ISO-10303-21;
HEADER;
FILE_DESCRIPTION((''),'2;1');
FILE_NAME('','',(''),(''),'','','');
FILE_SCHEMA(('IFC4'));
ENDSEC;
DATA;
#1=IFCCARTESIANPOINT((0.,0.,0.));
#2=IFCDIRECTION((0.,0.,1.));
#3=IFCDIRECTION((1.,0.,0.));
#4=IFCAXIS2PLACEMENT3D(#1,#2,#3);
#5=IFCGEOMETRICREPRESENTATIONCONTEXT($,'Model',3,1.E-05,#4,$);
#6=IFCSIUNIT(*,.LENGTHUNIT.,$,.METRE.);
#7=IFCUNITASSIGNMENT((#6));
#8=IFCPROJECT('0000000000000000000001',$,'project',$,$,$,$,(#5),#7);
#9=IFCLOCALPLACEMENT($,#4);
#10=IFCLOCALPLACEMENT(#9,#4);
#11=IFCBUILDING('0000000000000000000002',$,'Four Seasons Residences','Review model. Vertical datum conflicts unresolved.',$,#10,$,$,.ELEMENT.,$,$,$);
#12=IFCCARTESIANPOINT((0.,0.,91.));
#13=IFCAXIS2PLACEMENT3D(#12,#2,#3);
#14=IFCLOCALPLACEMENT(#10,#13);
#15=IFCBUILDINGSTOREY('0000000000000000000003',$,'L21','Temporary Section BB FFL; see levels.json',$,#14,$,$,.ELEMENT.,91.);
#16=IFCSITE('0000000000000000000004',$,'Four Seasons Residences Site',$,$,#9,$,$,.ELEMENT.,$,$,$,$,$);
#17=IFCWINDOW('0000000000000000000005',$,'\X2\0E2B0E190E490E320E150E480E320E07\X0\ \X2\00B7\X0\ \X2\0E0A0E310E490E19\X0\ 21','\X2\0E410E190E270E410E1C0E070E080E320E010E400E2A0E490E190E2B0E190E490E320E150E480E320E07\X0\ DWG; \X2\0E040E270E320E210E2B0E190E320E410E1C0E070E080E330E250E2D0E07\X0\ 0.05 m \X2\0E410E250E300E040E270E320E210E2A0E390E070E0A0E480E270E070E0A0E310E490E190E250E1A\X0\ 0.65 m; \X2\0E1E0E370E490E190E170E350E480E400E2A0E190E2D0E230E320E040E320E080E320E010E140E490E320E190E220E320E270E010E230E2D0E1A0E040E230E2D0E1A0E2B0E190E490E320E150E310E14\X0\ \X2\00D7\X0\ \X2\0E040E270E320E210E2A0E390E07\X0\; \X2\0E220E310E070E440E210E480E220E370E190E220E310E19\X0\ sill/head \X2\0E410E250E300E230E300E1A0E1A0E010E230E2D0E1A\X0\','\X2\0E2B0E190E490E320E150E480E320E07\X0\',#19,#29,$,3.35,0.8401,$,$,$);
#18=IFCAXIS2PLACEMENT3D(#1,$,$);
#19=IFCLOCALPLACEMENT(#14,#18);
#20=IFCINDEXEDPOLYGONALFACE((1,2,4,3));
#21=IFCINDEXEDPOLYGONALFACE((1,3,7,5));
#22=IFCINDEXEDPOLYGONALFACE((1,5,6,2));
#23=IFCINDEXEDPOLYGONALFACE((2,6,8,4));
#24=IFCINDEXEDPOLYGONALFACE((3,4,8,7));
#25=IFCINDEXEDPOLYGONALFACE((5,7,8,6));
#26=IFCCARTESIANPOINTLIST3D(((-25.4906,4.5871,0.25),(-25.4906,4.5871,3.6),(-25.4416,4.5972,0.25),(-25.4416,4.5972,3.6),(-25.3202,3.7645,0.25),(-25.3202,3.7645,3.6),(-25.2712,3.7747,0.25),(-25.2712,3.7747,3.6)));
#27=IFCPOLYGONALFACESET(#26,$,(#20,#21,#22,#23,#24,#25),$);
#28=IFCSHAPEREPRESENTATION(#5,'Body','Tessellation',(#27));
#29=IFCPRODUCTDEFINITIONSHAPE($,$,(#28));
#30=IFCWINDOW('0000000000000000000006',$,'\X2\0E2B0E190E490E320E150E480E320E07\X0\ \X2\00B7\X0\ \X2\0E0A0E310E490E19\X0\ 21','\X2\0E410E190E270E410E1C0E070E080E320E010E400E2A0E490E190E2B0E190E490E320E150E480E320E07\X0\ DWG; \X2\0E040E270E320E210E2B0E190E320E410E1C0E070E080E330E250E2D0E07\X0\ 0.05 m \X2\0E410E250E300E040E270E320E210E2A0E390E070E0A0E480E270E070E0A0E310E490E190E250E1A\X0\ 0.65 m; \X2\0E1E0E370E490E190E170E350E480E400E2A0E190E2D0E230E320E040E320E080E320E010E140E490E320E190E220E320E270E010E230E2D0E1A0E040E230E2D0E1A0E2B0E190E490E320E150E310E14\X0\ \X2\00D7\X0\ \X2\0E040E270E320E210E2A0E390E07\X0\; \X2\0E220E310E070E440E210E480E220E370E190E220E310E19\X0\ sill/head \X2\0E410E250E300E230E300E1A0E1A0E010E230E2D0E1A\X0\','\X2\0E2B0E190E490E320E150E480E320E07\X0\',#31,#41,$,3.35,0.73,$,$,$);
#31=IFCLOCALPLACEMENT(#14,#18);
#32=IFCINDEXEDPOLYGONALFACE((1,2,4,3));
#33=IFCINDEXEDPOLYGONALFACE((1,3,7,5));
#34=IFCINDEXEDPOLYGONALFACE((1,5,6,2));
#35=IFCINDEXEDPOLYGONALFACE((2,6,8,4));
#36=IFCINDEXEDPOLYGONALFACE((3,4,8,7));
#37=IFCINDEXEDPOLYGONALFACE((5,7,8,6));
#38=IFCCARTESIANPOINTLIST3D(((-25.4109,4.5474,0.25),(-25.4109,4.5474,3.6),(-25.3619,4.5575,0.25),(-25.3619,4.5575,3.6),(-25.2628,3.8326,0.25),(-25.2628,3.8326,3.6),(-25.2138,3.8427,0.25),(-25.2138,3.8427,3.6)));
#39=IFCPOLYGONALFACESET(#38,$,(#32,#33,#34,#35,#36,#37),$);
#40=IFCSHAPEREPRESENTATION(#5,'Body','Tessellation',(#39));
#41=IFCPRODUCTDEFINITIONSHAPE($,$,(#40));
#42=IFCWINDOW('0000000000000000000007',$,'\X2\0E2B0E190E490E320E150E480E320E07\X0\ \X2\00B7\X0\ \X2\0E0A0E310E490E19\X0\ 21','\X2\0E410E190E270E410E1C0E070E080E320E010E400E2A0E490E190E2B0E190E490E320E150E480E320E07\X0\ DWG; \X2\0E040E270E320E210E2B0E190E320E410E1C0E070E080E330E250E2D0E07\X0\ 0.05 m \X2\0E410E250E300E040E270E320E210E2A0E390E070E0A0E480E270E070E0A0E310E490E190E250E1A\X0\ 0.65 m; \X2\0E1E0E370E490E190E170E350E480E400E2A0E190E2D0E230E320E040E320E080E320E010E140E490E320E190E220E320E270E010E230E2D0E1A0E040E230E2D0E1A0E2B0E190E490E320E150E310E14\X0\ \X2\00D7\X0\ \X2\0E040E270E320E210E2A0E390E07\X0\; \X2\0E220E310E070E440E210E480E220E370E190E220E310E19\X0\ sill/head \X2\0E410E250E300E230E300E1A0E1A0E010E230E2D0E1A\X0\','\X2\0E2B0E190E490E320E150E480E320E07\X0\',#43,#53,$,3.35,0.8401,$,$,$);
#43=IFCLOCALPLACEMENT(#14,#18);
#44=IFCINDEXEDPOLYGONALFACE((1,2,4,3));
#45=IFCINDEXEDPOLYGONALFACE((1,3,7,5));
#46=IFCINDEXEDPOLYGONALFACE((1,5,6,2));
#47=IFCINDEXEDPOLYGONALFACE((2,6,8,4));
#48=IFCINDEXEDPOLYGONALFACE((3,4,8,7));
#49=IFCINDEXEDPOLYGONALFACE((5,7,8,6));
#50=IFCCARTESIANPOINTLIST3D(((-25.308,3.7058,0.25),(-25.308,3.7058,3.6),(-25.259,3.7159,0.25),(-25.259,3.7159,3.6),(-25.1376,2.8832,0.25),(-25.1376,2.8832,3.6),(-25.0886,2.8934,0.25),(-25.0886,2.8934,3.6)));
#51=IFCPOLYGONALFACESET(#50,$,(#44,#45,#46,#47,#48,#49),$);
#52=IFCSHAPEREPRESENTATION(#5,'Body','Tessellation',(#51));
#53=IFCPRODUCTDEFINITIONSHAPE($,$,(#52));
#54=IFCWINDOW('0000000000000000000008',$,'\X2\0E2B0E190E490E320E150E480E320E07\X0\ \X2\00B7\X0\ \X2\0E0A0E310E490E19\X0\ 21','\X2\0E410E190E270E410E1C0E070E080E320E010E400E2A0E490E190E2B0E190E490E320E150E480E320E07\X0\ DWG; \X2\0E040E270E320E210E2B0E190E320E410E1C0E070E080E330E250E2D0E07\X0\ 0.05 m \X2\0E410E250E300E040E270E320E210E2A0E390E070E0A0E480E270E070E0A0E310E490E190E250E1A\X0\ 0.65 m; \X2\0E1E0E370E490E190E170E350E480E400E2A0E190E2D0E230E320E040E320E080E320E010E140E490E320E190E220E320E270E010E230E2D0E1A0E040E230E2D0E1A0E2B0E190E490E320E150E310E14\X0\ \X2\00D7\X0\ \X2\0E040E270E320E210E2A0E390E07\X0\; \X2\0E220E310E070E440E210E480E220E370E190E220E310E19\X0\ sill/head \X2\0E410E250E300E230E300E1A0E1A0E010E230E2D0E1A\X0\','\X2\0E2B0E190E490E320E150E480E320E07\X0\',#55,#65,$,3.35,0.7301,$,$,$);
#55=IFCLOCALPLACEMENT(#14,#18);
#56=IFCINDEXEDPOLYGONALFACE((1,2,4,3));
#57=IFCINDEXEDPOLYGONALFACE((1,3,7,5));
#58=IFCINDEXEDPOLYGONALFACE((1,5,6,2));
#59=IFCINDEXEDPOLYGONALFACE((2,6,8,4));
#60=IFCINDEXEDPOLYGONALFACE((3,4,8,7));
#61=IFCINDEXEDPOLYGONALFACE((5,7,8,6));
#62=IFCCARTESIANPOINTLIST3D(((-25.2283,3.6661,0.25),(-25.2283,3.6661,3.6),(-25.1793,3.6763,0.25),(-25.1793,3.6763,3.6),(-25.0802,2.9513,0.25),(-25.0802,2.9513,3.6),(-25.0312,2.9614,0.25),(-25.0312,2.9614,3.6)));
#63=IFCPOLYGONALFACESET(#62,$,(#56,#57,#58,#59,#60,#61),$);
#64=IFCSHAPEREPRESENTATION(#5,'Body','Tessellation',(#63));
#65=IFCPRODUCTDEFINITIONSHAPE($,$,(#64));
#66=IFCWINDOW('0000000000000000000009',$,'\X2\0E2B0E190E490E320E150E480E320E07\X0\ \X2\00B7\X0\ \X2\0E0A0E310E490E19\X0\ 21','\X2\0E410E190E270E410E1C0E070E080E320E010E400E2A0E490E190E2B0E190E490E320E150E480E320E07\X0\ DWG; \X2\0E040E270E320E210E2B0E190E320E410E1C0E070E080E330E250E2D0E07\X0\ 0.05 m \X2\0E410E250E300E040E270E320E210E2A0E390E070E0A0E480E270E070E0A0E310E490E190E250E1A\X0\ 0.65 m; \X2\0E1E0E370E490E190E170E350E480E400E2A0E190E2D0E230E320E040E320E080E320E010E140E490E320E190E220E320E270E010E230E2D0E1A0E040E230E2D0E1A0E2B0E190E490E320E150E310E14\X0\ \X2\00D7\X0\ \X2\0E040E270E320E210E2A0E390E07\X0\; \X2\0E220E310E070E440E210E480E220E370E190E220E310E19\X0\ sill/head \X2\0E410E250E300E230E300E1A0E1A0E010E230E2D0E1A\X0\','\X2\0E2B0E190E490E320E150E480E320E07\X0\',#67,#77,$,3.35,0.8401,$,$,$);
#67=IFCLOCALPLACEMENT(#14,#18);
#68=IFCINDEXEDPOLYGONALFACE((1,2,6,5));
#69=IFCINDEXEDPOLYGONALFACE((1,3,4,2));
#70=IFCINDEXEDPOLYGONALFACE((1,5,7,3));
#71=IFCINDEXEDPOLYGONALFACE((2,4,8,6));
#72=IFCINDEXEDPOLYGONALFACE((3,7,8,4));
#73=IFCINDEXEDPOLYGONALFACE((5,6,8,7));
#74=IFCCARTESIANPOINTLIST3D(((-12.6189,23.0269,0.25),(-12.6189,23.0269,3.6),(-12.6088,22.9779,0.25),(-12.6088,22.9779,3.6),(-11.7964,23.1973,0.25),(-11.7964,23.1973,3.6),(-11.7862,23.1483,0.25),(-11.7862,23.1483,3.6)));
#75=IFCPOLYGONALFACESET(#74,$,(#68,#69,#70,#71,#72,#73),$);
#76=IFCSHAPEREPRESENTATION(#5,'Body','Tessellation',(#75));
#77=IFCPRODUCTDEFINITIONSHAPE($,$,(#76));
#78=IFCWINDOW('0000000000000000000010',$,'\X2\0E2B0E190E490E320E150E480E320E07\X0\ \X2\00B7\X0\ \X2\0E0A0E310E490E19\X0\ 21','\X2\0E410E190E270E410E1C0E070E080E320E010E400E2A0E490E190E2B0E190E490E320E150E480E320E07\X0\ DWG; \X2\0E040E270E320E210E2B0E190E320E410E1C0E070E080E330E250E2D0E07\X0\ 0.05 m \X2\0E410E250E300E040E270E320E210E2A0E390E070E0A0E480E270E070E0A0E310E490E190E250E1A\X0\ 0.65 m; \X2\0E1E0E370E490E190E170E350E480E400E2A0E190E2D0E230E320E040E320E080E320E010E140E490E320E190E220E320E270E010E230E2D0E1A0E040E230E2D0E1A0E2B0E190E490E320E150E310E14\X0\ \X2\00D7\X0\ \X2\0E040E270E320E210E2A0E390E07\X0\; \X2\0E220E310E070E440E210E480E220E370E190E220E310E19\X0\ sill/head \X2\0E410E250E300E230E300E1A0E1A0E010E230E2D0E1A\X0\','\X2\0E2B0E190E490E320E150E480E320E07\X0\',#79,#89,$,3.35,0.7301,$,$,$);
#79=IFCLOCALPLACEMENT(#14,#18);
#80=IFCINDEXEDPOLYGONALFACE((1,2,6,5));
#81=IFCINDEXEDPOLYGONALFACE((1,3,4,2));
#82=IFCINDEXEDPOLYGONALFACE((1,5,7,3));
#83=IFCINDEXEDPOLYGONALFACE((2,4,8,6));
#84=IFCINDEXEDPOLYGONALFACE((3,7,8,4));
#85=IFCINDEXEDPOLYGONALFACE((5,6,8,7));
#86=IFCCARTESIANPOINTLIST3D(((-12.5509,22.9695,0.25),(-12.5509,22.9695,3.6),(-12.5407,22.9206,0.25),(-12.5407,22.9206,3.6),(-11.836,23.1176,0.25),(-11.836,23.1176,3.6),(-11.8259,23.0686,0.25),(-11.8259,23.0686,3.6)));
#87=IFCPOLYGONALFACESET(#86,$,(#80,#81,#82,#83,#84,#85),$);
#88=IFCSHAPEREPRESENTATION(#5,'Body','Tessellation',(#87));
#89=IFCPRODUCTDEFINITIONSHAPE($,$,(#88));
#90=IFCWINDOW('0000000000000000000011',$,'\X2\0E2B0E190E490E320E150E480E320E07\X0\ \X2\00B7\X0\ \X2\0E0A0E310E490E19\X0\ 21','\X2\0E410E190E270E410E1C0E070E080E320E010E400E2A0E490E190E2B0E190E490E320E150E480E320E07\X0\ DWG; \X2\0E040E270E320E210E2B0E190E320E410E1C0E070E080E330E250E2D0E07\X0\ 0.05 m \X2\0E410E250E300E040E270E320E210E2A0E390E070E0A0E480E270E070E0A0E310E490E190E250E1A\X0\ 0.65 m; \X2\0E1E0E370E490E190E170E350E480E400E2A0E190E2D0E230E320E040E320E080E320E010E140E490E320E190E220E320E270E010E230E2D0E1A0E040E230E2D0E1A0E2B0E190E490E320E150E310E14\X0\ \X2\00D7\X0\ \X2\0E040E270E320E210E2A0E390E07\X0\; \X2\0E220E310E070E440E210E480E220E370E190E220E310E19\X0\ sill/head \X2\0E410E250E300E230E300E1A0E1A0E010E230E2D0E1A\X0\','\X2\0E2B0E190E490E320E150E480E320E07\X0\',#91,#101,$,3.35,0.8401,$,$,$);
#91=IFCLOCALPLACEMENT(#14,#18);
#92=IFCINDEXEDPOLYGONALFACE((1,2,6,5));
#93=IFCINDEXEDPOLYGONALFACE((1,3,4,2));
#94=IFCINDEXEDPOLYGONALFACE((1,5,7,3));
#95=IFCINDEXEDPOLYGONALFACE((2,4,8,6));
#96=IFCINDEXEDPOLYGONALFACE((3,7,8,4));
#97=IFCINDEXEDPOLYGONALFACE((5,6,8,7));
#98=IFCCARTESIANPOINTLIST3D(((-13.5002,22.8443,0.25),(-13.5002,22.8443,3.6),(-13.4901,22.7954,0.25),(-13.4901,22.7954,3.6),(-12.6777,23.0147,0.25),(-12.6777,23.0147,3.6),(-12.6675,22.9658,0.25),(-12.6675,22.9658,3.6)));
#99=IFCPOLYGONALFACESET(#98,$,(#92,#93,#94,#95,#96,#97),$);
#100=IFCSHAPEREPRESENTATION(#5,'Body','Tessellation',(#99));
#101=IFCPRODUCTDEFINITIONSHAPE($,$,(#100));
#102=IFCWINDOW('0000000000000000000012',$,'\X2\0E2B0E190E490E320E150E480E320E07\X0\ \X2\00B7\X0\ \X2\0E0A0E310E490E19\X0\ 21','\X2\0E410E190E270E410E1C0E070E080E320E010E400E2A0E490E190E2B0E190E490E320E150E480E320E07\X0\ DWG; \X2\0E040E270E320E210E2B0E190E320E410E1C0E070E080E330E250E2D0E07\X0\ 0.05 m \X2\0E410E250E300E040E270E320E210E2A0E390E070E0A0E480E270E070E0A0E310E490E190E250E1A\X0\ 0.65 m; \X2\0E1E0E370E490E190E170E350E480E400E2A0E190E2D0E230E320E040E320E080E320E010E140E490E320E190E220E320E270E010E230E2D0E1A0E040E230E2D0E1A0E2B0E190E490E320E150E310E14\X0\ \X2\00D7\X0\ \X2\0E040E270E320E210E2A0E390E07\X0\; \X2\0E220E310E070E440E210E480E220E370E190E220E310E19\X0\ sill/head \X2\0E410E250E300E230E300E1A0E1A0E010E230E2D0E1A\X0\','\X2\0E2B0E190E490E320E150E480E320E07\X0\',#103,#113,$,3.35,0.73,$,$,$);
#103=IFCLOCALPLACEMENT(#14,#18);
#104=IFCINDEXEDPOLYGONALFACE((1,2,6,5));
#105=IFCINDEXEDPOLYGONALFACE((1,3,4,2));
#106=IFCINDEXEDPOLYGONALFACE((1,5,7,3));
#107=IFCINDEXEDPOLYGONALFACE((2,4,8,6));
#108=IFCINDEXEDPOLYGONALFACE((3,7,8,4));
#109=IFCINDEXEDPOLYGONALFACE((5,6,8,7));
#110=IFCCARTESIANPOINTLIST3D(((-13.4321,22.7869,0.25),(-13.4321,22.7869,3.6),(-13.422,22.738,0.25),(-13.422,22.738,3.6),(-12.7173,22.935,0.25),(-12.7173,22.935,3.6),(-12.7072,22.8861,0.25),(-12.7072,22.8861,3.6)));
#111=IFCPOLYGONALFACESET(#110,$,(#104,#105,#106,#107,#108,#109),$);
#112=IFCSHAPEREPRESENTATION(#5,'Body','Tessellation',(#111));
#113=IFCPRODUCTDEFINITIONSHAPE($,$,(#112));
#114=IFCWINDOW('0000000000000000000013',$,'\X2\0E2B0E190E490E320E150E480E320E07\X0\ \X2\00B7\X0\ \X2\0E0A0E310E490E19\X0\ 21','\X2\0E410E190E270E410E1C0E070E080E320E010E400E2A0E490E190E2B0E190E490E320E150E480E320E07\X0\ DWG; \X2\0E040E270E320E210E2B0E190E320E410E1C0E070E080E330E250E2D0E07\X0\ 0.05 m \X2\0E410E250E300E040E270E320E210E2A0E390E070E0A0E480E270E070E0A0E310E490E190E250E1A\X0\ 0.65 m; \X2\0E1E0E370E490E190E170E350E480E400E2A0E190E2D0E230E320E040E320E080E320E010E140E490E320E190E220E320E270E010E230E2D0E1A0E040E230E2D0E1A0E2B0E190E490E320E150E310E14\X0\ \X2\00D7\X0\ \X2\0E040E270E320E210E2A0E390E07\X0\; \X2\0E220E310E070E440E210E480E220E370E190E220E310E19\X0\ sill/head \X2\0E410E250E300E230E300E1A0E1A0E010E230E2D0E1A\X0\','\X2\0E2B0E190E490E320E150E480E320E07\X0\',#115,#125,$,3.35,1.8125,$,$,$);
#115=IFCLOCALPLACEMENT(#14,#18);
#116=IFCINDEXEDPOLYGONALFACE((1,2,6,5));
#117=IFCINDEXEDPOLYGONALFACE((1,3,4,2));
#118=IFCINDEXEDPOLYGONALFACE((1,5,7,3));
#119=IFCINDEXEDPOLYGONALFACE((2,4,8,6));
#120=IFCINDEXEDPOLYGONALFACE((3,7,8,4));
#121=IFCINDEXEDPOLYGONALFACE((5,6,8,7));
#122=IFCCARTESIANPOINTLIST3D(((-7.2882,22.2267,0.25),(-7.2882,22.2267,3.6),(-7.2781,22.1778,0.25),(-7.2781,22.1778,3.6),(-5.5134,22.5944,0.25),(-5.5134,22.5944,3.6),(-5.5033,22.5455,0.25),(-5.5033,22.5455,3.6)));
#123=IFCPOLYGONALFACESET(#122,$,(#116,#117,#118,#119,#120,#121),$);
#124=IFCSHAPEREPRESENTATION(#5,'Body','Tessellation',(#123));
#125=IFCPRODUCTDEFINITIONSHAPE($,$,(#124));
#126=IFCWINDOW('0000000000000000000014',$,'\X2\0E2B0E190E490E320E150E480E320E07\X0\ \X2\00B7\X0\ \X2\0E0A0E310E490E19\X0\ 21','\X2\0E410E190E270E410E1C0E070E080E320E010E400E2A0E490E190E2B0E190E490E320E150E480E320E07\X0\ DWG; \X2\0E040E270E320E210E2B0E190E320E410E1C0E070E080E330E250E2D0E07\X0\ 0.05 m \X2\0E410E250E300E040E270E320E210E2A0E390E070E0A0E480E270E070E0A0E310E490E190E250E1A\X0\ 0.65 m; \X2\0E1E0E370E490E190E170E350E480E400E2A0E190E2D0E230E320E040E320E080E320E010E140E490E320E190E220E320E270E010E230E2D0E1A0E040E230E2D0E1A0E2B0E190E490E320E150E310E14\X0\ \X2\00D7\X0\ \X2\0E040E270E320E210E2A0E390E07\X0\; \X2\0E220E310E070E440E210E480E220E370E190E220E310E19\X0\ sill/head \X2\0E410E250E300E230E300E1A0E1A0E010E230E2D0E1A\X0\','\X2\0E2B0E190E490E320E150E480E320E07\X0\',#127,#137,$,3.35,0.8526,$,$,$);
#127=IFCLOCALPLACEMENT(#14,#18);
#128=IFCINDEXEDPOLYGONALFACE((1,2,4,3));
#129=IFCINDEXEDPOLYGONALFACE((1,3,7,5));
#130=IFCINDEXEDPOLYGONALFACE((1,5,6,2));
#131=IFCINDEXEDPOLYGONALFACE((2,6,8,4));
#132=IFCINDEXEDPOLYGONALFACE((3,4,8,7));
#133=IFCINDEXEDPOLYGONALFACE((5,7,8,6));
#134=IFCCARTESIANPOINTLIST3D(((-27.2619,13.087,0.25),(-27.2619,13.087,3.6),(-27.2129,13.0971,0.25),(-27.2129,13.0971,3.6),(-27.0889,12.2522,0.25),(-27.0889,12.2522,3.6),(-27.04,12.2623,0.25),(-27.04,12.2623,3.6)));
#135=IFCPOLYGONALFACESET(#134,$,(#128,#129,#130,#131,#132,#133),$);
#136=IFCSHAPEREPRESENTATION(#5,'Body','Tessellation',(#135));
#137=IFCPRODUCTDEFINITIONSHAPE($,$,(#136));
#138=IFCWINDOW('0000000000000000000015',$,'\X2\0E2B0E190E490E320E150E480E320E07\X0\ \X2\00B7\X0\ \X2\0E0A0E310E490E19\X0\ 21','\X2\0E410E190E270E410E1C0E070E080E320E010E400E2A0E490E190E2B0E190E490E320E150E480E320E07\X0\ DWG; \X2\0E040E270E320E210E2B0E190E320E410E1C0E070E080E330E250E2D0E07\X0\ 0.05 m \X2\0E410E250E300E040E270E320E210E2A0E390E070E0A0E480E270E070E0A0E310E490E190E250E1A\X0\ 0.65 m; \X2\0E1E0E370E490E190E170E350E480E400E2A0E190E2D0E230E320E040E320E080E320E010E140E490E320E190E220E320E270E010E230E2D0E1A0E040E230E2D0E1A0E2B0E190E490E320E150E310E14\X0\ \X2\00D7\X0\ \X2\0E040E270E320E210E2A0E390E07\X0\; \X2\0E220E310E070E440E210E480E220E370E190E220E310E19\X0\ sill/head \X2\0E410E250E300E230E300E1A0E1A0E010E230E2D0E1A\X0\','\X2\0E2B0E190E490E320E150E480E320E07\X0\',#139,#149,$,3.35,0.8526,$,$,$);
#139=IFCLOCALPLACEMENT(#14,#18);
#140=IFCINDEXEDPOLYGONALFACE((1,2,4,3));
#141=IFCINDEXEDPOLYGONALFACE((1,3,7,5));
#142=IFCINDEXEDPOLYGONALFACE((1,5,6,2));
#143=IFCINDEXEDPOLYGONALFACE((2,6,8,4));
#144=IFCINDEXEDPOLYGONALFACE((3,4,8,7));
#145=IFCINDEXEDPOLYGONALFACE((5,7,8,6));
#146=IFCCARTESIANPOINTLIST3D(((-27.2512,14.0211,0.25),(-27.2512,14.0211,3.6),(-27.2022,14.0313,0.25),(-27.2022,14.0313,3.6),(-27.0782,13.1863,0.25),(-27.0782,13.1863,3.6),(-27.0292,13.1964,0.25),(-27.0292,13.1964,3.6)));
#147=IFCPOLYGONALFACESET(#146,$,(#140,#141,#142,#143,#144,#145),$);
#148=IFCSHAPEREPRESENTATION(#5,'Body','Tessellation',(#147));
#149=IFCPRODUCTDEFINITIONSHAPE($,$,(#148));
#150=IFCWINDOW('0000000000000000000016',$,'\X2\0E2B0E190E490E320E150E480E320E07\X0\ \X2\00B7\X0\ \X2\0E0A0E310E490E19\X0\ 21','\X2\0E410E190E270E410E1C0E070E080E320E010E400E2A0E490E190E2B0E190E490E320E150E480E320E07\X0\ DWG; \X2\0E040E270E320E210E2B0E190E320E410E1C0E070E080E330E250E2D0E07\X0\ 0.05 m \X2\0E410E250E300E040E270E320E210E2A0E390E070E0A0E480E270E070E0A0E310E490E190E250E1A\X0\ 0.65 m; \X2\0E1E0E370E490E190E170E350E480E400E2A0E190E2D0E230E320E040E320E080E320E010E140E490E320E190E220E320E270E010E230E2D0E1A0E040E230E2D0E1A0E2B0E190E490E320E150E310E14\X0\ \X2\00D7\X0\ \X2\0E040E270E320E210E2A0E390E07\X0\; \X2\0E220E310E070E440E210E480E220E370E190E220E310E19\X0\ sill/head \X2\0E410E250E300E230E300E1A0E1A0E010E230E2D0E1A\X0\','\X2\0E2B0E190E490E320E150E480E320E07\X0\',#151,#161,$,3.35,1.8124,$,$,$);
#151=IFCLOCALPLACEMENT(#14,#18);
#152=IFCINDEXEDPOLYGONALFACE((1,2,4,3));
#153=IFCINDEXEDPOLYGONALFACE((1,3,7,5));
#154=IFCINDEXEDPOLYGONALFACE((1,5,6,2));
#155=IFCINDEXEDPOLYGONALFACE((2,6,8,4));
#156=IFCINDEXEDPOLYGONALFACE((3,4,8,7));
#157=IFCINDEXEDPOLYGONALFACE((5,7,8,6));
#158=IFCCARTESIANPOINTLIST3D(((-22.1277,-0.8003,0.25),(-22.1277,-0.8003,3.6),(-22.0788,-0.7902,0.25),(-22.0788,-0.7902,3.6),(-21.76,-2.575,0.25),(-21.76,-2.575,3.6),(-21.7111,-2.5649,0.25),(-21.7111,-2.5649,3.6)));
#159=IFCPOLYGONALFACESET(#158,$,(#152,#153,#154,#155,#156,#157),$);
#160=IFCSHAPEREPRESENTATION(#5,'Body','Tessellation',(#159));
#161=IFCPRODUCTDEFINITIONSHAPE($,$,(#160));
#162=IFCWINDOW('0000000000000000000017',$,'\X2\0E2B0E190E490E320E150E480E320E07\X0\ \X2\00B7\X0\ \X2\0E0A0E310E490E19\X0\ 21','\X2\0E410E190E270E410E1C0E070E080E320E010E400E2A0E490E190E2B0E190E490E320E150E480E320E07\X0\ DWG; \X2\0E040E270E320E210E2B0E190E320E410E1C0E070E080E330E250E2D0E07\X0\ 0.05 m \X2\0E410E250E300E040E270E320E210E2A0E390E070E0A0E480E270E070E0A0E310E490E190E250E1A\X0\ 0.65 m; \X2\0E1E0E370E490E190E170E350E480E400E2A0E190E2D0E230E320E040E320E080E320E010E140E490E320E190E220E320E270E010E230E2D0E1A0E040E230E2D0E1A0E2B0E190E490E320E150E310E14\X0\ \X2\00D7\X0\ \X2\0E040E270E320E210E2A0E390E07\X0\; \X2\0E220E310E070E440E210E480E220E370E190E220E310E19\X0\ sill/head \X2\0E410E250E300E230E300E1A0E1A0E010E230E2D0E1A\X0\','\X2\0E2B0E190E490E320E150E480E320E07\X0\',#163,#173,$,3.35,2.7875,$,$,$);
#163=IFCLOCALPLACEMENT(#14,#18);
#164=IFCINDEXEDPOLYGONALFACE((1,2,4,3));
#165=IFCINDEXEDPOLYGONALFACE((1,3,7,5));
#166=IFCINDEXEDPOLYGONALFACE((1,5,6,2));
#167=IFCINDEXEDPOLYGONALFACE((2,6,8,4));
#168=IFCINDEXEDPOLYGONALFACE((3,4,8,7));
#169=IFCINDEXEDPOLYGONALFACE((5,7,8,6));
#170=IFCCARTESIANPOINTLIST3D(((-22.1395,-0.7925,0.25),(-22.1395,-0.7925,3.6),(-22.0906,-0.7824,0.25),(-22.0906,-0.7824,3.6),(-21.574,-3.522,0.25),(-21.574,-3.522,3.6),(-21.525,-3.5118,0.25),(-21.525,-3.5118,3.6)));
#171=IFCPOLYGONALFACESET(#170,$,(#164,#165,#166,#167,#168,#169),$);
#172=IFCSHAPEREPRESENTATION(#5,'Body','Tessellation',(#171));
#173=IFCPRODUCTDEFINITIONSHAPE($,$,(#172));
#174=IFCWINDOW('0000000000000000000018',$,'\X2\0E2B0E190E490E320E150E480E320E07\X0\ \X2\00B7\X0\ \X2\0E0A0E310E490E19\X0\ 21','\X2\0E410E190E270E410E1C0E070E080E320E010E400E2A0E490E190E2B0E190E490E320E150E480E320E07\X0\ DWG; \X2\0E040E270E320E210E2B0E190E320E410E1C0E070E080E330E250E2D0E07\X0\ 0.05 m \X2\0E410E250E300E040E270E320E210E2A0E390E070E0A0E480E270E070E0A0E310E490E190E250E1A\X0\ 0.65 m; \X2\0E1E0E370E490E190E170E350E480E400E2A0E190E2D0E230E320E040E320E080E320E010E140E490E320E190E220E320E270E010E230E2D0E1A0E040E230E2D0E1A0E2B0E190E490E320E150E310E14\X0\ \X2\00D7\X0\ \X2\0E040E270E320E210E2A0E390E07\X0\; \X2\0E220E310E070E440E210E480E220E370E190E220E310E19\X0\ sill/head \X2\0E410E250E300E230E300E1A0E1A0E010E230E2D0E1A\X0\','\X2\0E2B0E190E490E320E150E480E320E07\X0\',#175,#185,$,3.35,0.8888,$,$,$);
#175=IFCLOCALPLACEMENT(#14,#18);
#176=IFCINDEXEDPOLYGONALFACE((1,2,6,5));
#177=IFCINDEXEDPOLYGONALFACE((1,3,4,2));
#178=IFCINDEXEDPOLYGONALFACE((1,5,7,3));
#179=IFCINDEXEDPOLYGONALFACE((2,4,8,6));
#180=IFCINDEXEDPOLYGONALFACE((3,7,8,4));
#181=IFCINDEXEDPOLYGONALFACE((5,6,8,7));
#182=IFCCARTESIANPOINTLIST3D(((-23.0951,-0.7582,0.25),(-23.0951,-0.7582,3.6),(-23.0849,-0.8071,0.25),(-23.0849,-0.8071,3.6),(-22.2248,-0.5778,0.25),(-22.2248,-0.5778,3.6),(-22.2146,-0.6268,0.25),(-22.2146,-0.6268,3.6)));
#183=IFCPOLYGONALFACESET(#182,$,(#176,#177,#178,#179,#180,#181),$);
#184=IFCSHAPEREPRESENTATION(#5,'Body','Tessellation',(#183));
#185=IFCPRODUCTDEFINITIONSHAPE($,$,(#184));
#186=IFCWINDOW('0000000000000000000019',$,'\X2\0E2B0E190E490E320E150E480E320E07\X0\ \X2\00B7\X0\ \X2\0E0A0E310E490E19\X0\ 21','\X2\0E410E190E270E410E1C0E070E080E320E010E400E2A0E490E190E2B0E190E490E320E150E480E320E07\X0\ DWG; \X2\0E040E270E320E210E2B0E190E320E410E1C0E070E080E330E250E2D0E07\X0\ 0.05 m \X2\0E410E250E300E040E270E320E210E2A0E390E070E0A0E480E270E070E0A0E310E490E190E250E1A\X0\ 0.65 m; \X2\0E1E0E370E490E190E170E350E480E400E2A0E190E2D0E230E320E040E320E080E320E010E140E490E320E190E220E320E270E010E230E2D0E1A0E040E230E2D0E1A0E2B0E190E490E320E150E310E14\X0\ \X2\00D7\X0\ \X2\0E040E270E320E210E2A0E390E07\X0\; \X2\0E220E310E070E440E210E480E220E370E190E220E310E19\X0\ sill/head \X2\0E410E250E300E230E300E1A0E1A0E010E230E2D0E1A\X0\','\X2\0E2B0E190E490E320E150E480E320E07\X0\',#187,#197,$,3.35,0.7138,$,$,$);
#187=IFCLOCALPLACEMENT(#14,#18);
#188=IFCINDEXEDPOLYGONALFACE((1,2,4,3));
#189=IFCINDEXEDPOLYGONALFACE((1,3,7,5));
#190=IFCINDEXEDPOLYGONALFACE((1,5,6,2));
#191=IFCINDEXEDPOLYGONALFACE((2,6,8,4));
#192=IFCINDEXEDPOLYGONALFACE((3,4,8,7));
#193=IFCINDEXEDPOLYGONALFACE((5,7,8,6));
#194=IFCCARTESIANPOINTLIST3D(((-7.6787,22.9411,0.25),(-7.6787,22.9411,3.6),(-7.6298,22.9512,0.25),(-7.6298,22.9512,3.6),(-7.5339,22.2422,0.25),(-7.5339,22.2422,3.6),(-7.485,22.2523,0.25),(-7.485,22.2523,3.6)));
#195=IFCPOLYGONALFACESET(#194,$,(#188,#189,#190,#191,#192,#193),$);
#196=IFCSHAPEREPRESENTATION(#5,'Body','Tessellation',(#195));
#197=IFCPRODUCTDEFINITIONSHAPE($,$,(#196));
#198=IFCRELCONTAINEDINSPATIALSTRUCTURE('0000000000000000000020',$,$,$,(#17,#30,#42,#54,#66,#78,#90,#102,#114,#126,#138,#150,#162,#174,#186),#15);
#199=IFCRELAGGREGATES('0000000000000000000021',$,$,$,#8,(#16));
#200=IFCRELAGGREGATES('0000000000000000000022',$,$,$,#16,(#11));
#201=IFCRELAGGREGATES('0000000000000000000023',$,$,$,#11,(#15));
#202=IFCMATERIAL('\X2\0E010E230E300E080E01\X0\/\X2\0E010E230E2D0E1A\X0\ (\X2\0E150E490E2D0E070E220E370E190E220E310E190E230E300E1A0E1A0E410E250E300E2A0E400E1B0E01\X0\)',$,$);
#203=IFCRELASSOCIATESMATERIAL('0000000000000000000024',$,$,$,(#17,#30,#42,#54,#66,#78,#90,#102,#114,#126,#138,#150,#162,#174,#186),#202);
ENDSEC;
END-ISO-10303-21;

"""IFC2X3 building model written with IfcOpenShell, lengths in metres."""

from ifc_helpers import new_model, si_unit, frame, origin_with_axes, place, context, project, spatial, polyline, outline, extrude, material, element, save


model = new_model("IFC2X3")

# Units and contexts
model_context = context("Model", 3, precision=1e-05, world=origin_with_axes())
ifc_project = project(units=[si_unit("LENGTHUNIT", "METRE")], contexts=[model_context])

# Site, building, storey
site_placement = place(None, origin_with_axes())
site = spatial("IfcSite", under=ifc_project, at=site_placement, Name="Four Seasons Residences Site", CompositionType="ELEMENT")
building_placement = place(site_placement, origin_with_axes())
building = spatial("IfcBuilding", under=site, at=building_placement, Name="Four Seasons Residences", Description="Review model. Vertical datum conflicts unresolved.", CompositionType="ELEMENT")
storey_placement = place(building_placement, frame((0.0, 0.0, 91.0), z_axis=(0.0, 0.0, 1.0), x_axis=(1.0, 0.0, 0.0)))
storey = spatial("IfcBuildingStorey", under=building, at=storey_placement, Name="L21", Description="Temporary Section BB FFL; see levels.json", CompositionType="ELEMENT", Elevation=91.0)

# Windows
ifc_material = material(Name="กระจก/กรอบ (ต้องยืนยันระบบและสเปก)")
window_1_placement = place(storey_placement, origin_with_axes())
element("IfcWindow", 1, at=window_1_placement, inside=storey, material=ifc_material, Name="หน้าต่าง · ชั้น 21", Description="แนวแผงจากเส้นหน้าต่าง DWG; ความหนาแผงจำลอง 0.05 m และความสูงช่วงชั้นลบ 0.65 m; พื้นที่เสนอราคาจากด้านยาวกรอบครอบหน้าตัด × ความสูง; ยังไม่ยืนยัน sill/head และระบบกรอบ", ObjectType="หน้าต่าง", OverallHeight=3.35, OverallWidth=0.8401, context=model_context, shape_type="SweptSolid", body=[
    extrude(outline(polyline([(-25.2712, 3.7747), (-25.3202, 3.7645), (-25.4906, 4.5871), (-25.4416, 4.5972), (-25.2712, 3.7747)])), frame((0.0, 0.0, 0.25), z_axis=(0.0, 0.0, 1.0), x_axis=(1.0, 0.0, 0.0)), (0.0, 0.0, 1.0), 3.35),
])
window_2_placement = place(storey_placement, origin_with_axes())
element("IfcWindow", 2, at=window_2_placement, inside=storey, material=ifc_material, Name="หน้าต่าง · ชั้น 21", Description="แนวแผงจากเส้นหน้าต่าง DWG; ความหนาแผงจำลอง 0.05 m และความสูงช่วงชั้นลบ 0.65 m; พื้นที่เสนอราคาจากด้านยาวกรอบครอบหน้าตัด × ความสูง; ยังไม่ยืนยัน sill/head และระบบกรอบ", ObjectType="หน้าต่าง", OverallHeight=3.35, OverallWidth=0.73, context=model_context, shape_type="SweptSolid", body=[
    extrude(outline(polyline([(-25.2138, 3.8427), (-25.2628, 3.8326), (-25.4109, 4.5474), (-25.3619, 4.5575), (-25.2138, 3.8427)])), frame((0.0, 0.0, 0.25), z_axis=(0.0, 0.0, 1.0), x_axis=(1.0, 0.0, 0.0)), (0.0, 0.0, 1.0), 3.35),
])
window_3_placement = place(storey_placement, origin_with_axes())
element("IfcWindow", 3, at=window_3_placement, inside=storey, material=ifc_material, Name="หน้าต่าง · ชั้น 21", Description="แนวแผงจากเส้นหน้าต่าง DWG; ความหนาแผงจำลอง 0.05 m และความสูงช่วงชั้นลบ 0.65 m; พื้นที่เสนอราคาจากด้านยาวกรอบครอบหน้าตัด × ความสูง; ยังไม่ยืนยัน sill/head และระบบกรอบ", ObjectType="หน้าต่าง", OverallHeight=3.35, OverallWidth=0.8401, context=model_context, shape_type="SweptSolid", body=[
    extrude(outline(polyline([(-25.0886, 2.8934), (-25.1376, 2.8832), (-25.308, 3.7058), (-25.259, 3.7159), (-25.0886, 2.8934)])), frame((0.0, 0.0, 0.25), z_axis=(0.0, 0.0, 1.0), x_axis=(1.0, 0.0, 0.0)), (0.0, 0.0, 1.0), 3.35),
])
window_4_placement = place(storey_placement, origin_with_axes())
element("IfcWindow", 4, at=window_4_placement, inside=storey, material=ifc_material, Name="หน้าต่าง · ชั้น 21", Description="แนวแผงจากเส้นหน้าต่าง DWG; ความหนาแผงจำลอง 0.05 m และความสูงช่วงชั้นลบ 0.65 m; พื้นที่เสนอราคาจากด้านยาวกรอบครอบหน้าตัด × ความสูง; ยังไม่ยืนยัน sill/head และระบบกรอบ", ObjectType="หน้าต่าง", OverallHeight=3.35, OverallWidth=0.7301, context=model_context, shape_type="SweptSolid", body=[
    extrude(outline(polyline([(-25.0312, 2.9614), (-25.0802, 2.9513), (-25.2283, 3.6661), (-25.1793, 3.6763), (-25.0312, 2.9614)])), frame((0.0, 0.0, 0.25), z_axis=(0.0, 0.0, 1.0), x_axis=(1.0, 0.0, 0.0)), (0.0, 0.0, 1.0), 3.35),
])
window_5_placement = place(storey_placement, origin_with_axes())
element("IfcWindow", 5, at=window_5_placement, inside=storey, material=ifc_material, Name="หน้าต่าง · ชั้น 21", Description="แนวแผงจากเส้นหน้าต่าง DWG; ความหนาแผงจำลอง 0.05 m และความสูงช่วงชั้นลบ 0.65 m; พื้นที่เสนอราคาจากด้านยาวกรอบครอบหน้าตัด × ความสูง; ยังไม่ยืนยัน sill/head และระบบกรอบ", ObjectType="หน้าต่าง", OverallHeight=3.35, OverallWidth=0.8401, context=model_context, shape_type="SweptSolid", body=[
    extrude(outline(polyline([(-12.6088, 22.9779), (-12.6189, 23.0269), (-11.7964, 23.1973), (-11.7862, 23.1483), (-12.6088, 22.9779)])), frame((0.0, 0.0, 0.25), z_axis=(0.0, 0.0, 1.0), x_axis=(1.0, 0.0, 0.0)), (0.0, 0.0, 1.0), 3.35),
])
window_6_placement = place(storey_placement, origin_with_axes())
element("IfcWindow", 6, at=window_6_placement, inside=storey, material=ifc_material, Name="หน้าต่าง · ชั้น 21", Description="แนวแผงจากเส้นหน้าต่าง DWG; ความหนาแผงจำลอง 0.05 m และความสูงช่วงชั้นลบ 0.65 m; พื้นที่เสนอราคาจากด้านยาวกรอบครอบหน้าตัด × ความสูง; ยังไม่ยืนยัน sill/head และระบบกรอบ", ObjectType="หน้าต่าง", OverallHeight=3.35, OverallWidth=0.7301, context=model_context, shape_type="SweptSolid", body=[
    extrude(outline(polyline([(-12.5407, 22.9206), (-12.5509, 22.9695), (-11.836, 23.1176), (-11.8259, 23.0686), (-12.5407, 22.9206)])), frame((0.0, 0.0, 0.25), z_axis=(0.0, 0.0, 1.0), x_axis=(1.0, 0.0, 0.0)), (0.0, 0.0, 1.0), 3.35),
])
window_7_placement = place(storey_placement, origin_with_axes())
element("IfcWindow", 7, at=window_7_placement, inside=storey, material=ifc_material, Name="หน้าต่าง · ชั้น 21", Description="แนวแผงจากเส้นหน้าต่าง DWG; ความหนาแผงจำลอง 0.05 m และความสูงช่วงชั้นลบ 0.65 m; พื้นที่เสนอราคาจากด้านยาวกรอบครอบหน้าตัด × ความสูง; ยังไม่ยืนยัน sill/head และระบบกรอบ", ObjectType="หน้าต่าง", OverallHeight=3.35, OverallWidth=0.8401, context=model_context, shape_type="SweptSolid", body=[
    extrude(outline(polyline([(-13.4901, 22.7954), (-13.5002, 22.8443), (-12.6777, 23.0147), (-12.6675, 22.9658), (-13.4901, 22.7954)])), frame((0.0, 0.0, 0.25), z_axis=(0.0, 0.0, 1.0), x_axis=(1.0, 0.0, 0.0)), (0.0, 0.0, 1.0), 3.35),
])
window_8_placement = place(storey_placement, origin_with_axes())
element("IfcWindow", 8, at=window_8_placement, inside=storey, material=ifc_material, Name="หน้าต่าง · ชั้น 21", Description="แนวแผงจากเส้นหน้าต่าง DWG; ความหนาแผงจำลอง 0.05 m และความสูงช่วงชั้นลบ 0.65 m; พื้นที่เสนอราคาจากด้านยาวกรอบครอบหน้าตัด × ความสูง; ยังไม่ยืนยัน sill/head และระบบกรอบ", ObjectType="หน้าต่าง", OverallHeight=3.35, OverallWidth=0.73, context=model_context, shape_type="SweptSolid", body=[
    extrude(outline(polyline([(-13.422, 22.738), (-13.4321, 22.7869), (-12.7173, 22.935), (-12.7072, 22.8861), (-13.422, 22.738)])), frame((0.0, 0.0, 0.25), z_axis=(0.0, 0.0, 1.0), x_axis=(1.0, 0.0, 0.0)), (0.0, 0.0, 1.0), 3.35),
])
window_9_placement = place(storey_placement, origin_with_axes())
element("IfcWindow", 9, at=window_9_placement, inside=storey, material=ifc_material, Name="หน้าต่าง · ชั้น 21", Description="แนวแผงจากเส้นหน้าต่าง DWG; ความหนาแผงจำลอง 0.05 m และความสูงช่วงชั้นลบ 0.65 m; พื้นที่เสนอราคาจากด้านยาวกรอบครอบหน้าตัด × ความสูง; ยังไม่ยืนยัน sill/head และระบบกรอบ", ObjectType="หน้าต่าง", OverallHeight=3.35, OverallWidth=1.8125, context=model_context, shape_type="SweptSolid", body=[
    extrude(outline(polyline([(-7.2781, 22.1778), (-7.2882, 22.2267), (-5.5134, 22.5944), (-5.5033, 22.5455), (-7.2781, 22.1778)])), frame((0.0, 0.0, 0.25), z_axis=(0.0, 0.0, 1.0), x_axis=(1.0, 0.0, 0.0)), (0.0, 0.0, 1.0), 3.35),
])
window_10_placement = place(storey_placement, origin_with_axes())
element("IfcWindow", 10, at=window_10_placement, inside=storey, material=ifc_material, Name="หน้าต่าง · ชั้น 21", Description="แนวแผงจากเส้นหน้าต่าง DWG; ความหนาแผงจำลอง 0.05 m และความสูงช่วงชั้นลบ 0.65 m; พื้นที่เสนอราคาจากด้านยาวกรอบครอบหน้าตัด × ความสูง; ยังไม่ยืนยัน sill/head และระบบกรอบ", ObjectType="หน้าต่าง", OverallHeight=3.35, OverallWidth=0.8526, context=model_context, shape_type="SweptSolid", body=[
    extrude(outline(polyline([(-27.2619, 13.087), (-27.2129, 13.0971), (-27.04, 12.2623), (-27.0889, 12.2522), (-27.2619, 13.087)])), frame((0.0, 0.0, 0.25), z_axis=(0.0, 0.0, 1.0), x_axis=(1.0, 0.0, 0.0)), (0.0, 0.0, 1.0), 3.35),
])
window_11_placement = place(storey_placement, origin_with_axes())
element("IfcWindow", 11, at=window_11_placement, inside=storey, material=ifc_material, Name="หน้าต่าง · ชั้น 21", Description="แนวแผงจากเส้นหน้าต่าง DWG; ความหนาแผงจำลอง 0.05 m และความสูงช่วงชั้นลบ 0.65 m; พื้นที่เสนอราคาจากด้านยาวกรอบครอบหน้าตัด × ความสูง; ยังไม่ยืนยัน sill/head และระบบกรอบ", ObjectType="หน้าต่าง", OverallHeight=3.35, OverallWidth=0.8526, context=model_context, shape_type="SweptSolid", body=[
    extrude(outline(polyline([(-27.0292, 13.1964), (-27.0782, 13.1863), (-27.2512, 14.0211), (-27.2022, 14.0313), (-27.0292, 13.1964)])), frame((0.0, 0.0, 0.25), z_axis=(0.0, 0.0, 1.0), x_axis=(1.0, 0.0, 0.0)), (0.0, 0.0, 1.0), 3.35),
])
window_12_placement = place(storey_placement, origin_with_axes())
element("IfcWindow", 12, at=window_12_placement, inside=storey, material=ifc_material, Name="หน้าต่าง · ชั้น 21", Description="แนวแผงจากเส้นหน้าต่าง DWG; ความหนาแผงจำลอง 0.05 m และความสูงช่วงชั้นลบ 0.65 m; พื้นที่เสนอราคาจากด้านยาวกรอบครอบหน้าตัด × ความสูง; ยังไม่ยืนยัน sill/head และระบบกรอบ", ObjectType="หน้าต่าง", OverallHeight=3.35, OverallWidth=1.8124, context=model_context, shape_type="SweptSolid", body=[
    extrude(outline(polyline([(-21.7111, -2.5649), (-21.76, -2.575), (-22.1277, -0.8003), (-22.0788, -0.7902), (-21.7111, -2.5649)])), frame((0.0, 0.0, 0.25), z_axis=(0.0, 0.0, 1.0), x_axis=(1.0, 0.0, 0.0)), (0.0, 0.0, 1.0), 3.35),
])
window_13_placement = place(storey_placement, origin_with_axes())
element("IfcWindow", 13, at=window_13_placement, inside=storey, material=ifc_material, Name="หน้าต่าง · ชั้น 21", Description="แนวแผงจากเส้นหน้าต่าง DWG; ความหนาแผงจำลอง 0.05 m และความสูงช่วงชั้นลบ 0.65 m; พื้นที่เสนอราคาจากด้านยาวกรอบครอบหน้าตัด × ความสูง; ยังไม่ยืนยัน sill/head และระบบกรอบ", ObjectType="หน้าต่าง", OverallHeight=3.35, OverallWidth=2.7875, context=model_context, shape_type="SweptSolid", body=[
    extrude(outline(polyline([(-22.1395, -0.7925), (-22.0906, -0.7824), (-21.525, -3.5118), (-21.574, -3.522), (-22.1395, -0.7925)])), frame((0.0, 0.0, 0.25), z_axis=(0.0, 0.0, 1.0), x_axis=(1.0, 0.0, 0.0)), (0.0, 0.0, 1.0), 3.35),
])
window_14_placement = place(storey_placement, origin_with_axes())
element("IfcWindow", 14, at=window_14_placement, inside=storey, material=ifc_material, Name="หน้าต่าง · ชั้น 21", Description="แนวแผงจากเส้นหน้าต่าง DWG; ความหนาแผงจำลอง 0.05 m และความสูงช่วงชั้นลบ 0.65 m; พื้นที่เสนอราคาจากด้านยาวกรอบครอบหน้าตัด × ความสูง; ยังไม่ยืนยัน sill/head และระบบกรอบ", ObjectType="หน้าต่าง", OverallHeight=3.35, OverallWidth=0.8888, context=model_context, shape_type="SweptSolid", body=[
    extrude(outline(polyline([(-23.0849, -0.8071), (-23.0951, -0.7582), (-22.2248, -0.5778), (-22.2146, -0.6268), (-23.0849, -0.8071)])), frame((0.0, 0.0, 0.25), z_axis=(0.0, 0.0, 1.0), x_axis=(1.0, 0.0, 0.0)), (0.0, 0.0, 1.0), 3.35),
])
window_15_placement = place(storey_placement, origin_with_axes())
element("IfcWindow", 15, at=window_15_placement, inside=storey, material=ifc_material, Name="หน้าต่าง · ชั้น 21", Description="แนวแผงจากเส้นหน้าต่าง DWG; ความหนาแผงจำลอง 0.05 m และความสูงช่วงชั้นลบ 0.65 m; พื้นที่เสนอราคาจากด้านยาวกรอบครอบหน้าตัด × ความสูง; ยังไม่ยืนยัน sill/head และระบบกรอบ", ObjectType="หน้าต่าง", OverallHeight=3.35, OverallWidth=0.7138, context=model_context, shape_type="SweptSolid", body=[
    extrude(outline(polyline([(-7.6787, 22.9411), (-7.6298, 22.9512), (-7.485, 22.2523), (-7.5339, 22.2422), (-7.6787, 22.9411)])), frame((0.0, 0.0, 0.25), z_axis=(0.0, 0.0, 1.0), x_axis=(1.0, 0.0, 0.0)), (0.0, 0.0, 1.0), 3.35),
])

save(model, "model.ifc")
